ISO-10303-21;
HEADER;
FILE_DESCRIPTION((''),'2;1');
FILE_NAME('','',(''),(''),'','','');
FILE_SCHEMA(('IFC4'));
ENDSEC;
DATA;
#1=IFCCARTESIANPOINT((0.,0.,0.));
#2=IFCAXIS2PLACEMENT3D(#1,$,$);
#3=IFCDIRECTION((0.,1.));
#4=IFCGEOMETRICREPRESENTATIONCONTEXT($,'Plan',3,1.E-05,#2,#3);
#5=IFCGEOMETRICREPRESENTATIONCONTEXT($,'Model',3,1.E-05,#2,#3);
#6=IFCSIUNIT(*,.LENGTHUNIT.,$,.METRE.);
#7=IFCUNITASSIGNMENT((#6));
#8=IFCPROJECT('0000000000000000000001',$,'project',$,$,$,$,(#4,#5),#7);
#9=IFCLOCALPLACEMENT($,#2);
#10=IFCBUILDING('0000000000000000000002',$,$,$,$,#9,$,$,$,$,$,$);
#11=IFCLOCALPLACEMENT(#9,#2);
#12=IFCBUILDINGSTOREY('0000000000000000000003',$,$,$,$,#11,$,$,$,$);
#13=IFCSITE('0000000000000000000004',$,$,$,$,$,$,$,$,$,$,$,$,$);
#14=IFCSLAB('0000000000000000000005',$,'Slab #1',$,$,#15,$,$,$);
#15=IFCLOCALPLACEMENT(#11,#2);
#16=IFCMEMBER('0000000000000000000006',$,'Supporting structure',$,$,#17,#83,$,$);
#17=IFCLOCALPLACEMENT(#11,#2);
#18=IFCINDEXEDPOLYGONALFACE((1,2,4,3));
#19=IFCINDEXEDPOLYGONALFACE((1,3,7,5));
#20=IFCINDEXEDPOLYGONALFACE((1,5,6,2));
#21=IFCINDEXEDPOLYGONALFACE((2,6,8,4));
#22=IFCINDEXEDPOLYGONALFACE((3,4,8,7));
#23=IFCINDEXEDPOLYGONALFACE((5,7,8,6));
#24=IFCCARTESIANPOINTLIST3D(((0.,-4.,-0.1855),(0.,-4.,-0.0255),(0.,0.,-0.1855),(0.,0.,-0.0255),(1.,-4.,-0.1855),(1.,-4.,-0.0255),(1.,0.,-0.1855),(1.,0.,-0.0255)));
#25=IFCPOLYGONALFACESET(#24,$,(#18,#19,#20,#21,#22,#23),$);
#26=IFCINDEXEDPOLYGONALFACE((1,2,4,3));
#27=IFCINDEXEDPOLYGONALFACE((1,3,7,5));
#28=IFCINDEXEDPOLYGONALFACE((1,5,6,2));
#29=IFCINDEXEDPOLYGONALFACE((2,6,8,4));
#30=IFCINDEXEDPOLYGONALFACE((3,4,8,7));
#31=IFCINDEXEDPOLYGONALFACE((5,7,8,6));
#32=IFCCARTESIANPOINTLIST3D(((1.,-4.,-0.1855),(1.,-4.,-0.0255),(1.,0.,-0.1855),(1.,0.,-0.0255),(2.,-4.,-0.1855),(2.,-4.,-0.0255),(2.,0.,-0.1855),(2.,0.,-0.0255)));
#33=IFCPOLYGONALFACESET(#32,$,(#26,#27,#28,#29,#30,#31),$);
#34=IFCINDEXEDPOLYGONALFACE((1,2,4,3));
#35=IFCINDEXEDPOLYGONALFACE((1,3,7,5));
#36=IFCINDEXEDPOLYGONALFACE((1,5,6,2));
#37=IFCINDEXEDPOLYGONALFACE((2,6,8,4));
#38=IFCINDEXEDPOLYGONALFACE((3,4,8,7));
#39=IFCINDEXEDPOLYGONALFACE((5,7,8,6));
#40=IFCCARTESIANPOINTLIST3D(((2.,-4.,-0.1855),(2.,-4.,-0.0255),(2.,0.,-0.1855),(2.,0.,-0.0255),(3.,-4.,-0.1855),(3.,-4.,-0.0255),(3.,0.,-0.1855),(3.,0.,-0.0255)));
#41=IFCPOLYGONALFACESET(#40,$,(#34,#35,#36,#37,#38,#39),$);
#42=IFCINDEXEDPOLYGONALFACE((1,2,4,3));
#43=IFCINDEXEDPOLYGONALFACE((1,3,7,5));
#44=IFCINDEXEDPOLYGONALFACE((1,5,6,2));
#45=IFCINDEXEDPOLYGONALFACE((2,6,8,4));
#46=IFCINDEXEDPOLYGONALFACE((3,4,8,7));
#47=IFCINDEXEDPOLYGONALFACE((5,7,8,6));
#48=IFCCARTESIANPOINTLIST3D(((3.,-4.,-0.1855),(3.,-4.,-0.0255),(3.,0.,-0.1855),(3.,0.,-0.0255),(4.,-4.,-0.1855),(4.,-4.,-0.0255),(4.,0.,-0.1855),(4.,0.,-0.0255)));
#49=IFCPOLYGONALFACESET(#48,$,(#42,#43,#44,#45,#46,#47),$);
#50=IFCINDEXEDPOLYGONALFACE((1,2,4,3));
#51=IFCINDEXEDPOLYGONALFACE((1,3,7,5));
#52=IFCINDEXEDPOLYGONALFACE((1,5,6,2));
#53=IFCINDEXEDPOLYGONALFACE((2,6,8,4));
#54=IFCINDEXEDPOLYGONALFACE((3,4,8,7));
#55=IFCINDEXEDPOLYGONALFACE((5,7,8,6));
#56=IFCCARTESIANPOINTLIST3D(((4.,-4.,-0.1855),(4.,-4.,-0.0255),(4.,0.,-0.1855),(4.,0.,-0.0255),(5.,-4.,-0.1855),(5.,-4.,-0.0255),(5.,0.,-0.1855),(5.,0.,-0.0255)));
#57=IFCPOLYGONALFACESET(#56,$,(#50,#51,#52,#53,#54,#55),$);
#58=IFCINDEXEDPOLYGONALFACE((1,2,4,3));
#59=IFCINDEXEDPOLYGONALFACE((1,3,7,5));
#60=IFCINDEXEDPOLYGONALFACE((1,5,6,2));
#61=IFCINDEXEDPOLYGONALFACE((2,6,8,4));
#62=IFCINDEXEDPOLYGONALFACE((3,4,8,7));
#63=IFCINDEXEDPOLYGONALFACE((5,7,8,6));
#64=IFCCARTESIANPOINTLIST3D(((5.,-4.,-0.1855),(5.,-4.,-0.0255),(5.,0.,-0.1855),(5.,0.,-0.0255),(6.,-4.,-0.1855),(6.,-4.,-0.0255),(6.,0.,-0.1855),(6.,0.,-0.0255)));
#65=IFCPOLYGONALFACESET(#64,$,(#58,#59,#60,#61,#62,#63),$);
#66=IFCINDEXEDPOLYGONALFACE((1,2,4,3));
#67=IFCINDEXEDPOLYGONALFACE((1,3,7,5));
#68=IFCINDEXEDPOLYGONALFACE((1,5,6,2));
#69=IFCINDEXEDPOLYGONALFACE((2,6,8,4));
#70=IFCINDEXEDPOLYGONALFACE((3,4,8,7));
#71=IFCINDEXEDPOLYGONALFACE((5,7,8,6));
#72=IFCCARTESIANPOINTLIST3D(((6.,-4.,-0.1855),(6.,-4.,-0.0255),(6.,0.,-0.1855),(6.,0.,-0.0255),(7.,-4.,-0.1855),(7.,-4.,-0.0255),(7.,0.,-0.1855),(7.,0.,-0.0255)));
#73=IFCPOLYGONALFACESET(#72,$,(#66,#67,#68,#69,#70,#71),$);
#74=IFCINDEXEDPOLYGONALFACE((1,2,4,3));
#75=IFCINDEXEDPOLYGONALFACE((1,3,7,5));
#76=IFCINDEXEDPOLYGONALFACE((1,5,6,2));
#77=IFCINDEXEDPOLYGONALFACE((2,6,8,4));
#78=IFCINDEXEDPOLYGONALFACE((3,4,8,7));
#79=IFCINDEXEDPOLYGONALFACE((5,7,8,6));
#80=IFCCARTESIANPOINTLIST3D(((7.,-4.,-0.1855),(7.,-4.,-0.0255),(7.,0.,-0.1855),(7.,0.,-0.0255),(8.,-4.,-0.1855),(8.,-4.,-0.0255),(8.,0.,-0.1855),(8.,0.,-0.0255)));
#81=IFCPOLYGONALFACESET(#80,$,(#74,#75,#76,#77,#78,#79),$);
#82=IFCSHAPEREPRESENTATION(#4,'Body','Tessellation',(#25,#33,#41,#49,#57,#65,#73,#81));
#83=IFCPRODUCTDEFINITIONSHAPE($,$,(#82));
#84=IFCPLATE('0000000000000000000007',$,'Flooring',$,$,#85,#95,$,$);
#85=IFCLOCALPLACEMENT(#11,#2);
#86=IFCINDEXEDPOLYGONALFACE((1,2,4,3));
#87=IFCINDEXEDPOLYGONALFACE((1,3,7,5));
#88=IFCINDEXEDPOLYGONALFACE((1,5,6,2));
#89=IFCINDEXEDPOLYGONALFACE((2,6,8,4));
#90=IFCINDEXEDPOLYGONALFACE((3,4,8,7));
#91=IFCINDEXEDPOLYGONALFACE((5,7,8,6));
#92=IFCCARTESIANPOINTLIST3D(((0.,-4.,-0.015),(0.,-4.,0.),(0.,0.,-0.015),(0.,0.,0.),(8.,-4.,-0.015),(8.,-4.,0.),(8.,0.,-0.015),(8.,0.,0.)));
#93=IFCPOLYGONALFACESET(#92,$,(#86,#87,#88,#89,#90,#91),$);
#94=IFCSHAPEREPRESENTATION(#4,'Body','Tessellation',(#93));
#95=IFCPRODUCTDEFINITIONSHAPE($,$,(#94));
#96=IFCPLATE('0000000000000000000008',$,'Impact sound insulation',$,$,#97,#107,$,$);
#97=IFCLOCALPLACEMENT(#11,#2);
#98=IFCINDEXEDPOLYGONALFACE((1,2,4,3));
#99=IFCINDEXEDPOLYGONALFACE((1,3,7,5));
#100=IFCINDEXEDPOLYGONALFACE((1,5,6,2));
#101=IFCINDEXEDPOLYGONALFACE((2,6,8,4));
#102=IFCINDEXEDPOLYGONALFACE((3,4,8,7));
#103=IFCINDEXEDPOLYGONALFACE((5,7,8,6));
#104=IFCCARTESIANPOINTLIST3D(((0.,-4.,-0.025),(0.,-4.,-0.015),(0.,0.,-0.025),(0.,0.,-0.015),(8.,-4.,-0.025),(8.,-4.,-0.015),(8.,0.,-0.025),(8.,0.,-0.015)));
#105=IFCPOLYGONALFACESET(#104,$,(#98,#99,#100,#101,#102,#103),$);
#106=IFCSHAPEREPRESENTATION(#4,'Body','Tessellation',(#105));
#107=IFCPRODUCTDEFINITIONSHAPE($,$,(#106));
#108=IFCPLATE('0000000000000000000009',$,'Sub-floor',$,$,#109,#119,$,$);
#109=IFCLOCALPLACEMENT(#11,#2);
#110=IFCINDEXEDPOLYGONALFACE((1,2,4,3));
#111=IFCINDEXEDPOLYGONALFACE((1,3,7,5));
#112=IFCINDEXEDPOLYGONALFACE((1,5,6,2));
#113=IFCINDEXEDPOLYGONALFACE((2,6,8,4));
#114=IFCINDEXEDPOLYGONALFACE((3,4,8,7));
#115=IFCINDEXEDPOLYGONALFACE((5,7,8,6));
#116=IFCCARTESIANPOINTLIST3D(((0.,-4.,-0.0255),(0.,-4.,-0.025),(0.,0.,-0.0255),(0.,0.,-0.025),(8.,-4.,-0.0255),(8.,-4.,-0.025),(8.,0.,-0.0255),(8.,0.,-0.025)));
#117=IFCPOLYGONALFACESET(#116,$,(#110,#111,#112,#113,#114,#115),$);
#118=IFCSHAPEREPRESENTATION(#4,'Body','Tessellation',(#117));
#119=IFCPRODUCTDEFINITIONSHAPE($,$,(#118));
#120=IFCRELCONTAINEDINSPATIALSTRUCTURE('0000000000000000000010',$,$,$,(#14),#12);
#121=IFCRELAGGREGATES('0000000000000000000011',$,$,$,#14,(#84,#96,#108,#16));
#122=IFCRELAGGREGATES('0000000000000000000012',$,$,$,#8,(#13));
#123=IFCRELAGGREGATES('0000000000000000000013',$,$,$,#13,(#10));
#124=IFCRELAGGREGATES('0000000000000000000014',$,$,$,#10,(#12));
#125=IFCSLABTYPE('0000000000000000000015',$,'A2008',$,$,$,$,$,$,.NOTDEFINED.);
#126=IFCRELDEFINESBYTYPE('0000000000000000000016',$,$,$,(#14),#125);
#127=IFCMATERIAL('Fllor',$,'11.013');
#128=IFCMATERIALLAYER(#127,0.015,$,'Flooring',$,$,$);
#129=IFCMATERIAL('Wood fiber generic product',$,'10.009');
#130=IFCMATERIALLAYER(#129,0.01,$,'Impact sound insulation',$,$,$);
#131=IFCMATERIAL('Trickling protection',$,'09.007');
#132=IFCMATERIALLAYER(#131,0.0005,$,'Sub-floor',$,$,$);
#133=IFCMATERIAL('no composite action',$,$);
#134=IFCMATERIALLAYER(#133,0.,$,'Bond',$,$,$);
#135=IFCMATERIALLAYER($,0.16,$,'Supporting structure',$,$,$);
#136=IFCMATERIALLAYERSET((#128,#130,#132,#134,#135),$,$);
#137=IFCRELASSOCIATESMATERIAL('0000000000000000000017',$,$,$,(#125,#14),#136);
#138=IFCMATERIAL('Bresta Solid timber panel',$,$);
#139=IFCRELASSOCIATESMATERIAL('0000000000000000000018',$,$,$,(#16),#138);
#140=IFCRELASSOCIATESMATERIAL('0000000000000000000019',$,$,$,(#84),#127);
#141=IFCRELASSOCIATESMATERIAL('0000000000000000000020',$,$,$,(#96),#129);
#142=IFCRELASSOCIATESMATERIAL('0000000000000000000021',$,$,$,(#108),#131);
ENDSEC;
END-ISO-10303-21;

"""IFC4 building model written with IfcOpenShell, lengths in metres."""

from ifc_helpers import new_model, si_unit, direction, frame, frame_2d, origin, origin_with_axes, place, context, project, spatial, rectangle, extrude, material, layer, layer_set, type_object, element, aggregate, save


model = new_model("IFC4")

# Units and contexts
plan_context = context("Plan", 3, precision=1e-05, world=origin(), true_north=direction((0.0, 1.0)))
model_context = context("Model", 3, precision=1e-05, world=origin(), true_north=direction((0.0, 1.0)))
ifc_project = project(units=[si_unit("LENGTHUNIT", "METRE")], contexts=[plan_context, model_context])

# Site, building, storey
site = spatial("IfcSite", under=ifc_project)
building_placement = place(None, origin())
building = spatial("IfcBuilding", under=site, at=building_placement)
storey_placement = place(building_placement, origin())
storey = spatial("IfcBuildingStorey", under=building, at=storey_placement)

# Slab, member, plates
ifc_material_1 = material(Name="Fllor", Category="11.013")
ifc_layer_1 = layer(ifc_material_1, 0.015, Name="Flooring")
ifc_material_2 = material(Name="Wood fiber generic product", Category="10.009")
ifc_layer_2 = layer(ifc_material_2, 0.01, Name="Impact sound insulation")
ifc_material_3 = material(Name="Trickling protection", Category="09.007")
ifc_layer_3 = layer(ifc_material_3, 0.0005, Name="Sub-floor")
ifc_material_4 = material(Name="no composite action")
ifc_layer_4 = layer(ifc_material_4, 0.0, Name="Bond")
ifc_layer_5 = layer(None, 0.16, Name="Supporting structure")
ifc_layer_set = layer_set([ifc_layer_1, ifc_layer_2, ifc_layer_3, ifc_layer_4, ifc_layer_5])
slab_type = type_object("IfcSlabType", Name="A2008", PredefinedType="NOTDEFINED", material=ifc_layer_set)
slab_placement = place(None, frame((0.0, 0.0, 0.0), z_axis=(0.0, 0.0, -1.0), x_axis=(1.0, 0.0, 0.0)))
slab = element("IfcSlab", 1, at=slab_placement, inside=storey, type_object=slab_type, material=ifc_layer_set, Name="Slab #1")
ifc_material_5 = material(Name="Bresta Solid timber panel")
member_placement = place(slab_placement, origin())
member = element("IfcMember", 2, at=member_placement, material=ifc_material_5, Name="Supporting structure", context=plan_context, shape_type="SweptSolid", body=[
    extrude(rectangle(XDim=1.0, YDim=0.16, at=frame_2d((0.5, 0.08), x_axis=(1.0, 0.0))), frame((0.0, 4.0, 0.0255), z_axis=(0.0, -1.0, 0.0), x_axis=(1.0, 0.0, 0.0)), (0.0, 0.0, 1.0), 4.0),
    extrude(rectangle(XDim=1.0, YDim=0.16, at=frame_2d((0.5, 0.08), x_axis=(1.0, 0.0))), frame((1.0, 4.0, 0.0255), z_axis=(0.0, -1.0, 0.0), x_axis=(1.0, 0.0, 0.0)), (0.0, 0.0, 1.0), 4.0),
    extrude(rectangle(XDim=1.0, YDim=0.16, at=frame_2d((0.5, 0.08), x_axis=(1.0, 0.0))), frame((2.0, 4.0, 0.0255), z_axis=(0.0, -1.0, 0.0), x_axis=(1.0, 0.0, 0.0)), (0.0, 0.0, 1.0), 4.0),
    extrude(rectangle(XDim=1.0, YDim=0.16, at=frame_2d((0.5, 0.08), x_axis=(1.0, 0.0))), frame((3.0, 4.0, 0.0255), z_axis=(0.0, -1.0, 0.0), x_axis=(1.0, 0.0, 0.0)), (0.0, 0.0, 1.0), 4.0),
    extrude(rectangle(XDim=1.0, YDim=0.16, at=frame_2d((0.5, 0.08), x_axis=(1.0, 0.0))), frame((4.0, 4.0, 0.0255), z_axis=(0.0, -1.0, 0.0), x_axis=(1.0, 0.0, 0.0)), (0.0, 0.0, 1.0), 4.0),
    extrude(rectangle(XDim=1.0, YDim=0.16, at=frame_2d((0.5, 0.08), x_axis=(1.0, 0.0))), frame((5.0, 4.0, 0.0255), z_axis=(0.0, -1.0, 0.0), x_axis=(1.0, 0.0, 0.0)), (0.0, 0.0, 1.0), 4.0),
    extrude(rectangle(XDim=1.0, YDim=0.16, at=frame_2d((0.5, 0.08), x_axis=(1.0, 0.0))), frame((6.0, 4.0, 0.0255), z_axis=(0.0, -1.0, 0.0), x_axis=(1.0, 0.0, 0.0)), (0.0, 0.0, 1.0), 4.0),
    extrude(rectangle(XDim=1.0, YDim=0.16, at=frame_2d((0.5, 0.08), x_axis=(1.0, 0.0))), frame((7.0, 4.0, 0.0255), z_axis=(0.0, -1.0, 0.0), x_axis=(1.0, 0.0, 0.0)), (0.0, 0.0, 1.0), 4.0),
])
plate_1_placement = place(slab_placement, origin())
plate_1 = element("IfcPlate", 3, at=plate_1_placement, material=ifc_material_1, Name="Flooring", context=plan_context, shape_type="SweptSolid", body=[
    extrude(rectangle(XDim=8.0, YDim=4.0, at=frame_2d((4.0, 2.0), x_axis=(1.0, 0.0))), origin_with_axes(), (0.0, 0.0, 1.0), 0.015),
])
plate_2_placement = place(slab_placement, origin())
plate_2 = element("IfcPlate", 4, at=plate_2_placement, material=ifc_material_2, Name="Impact sound insulation", context=plan_context, shape_type="SweptSolid", body=[
    extrude(rectangle(XDim=8.0, YDim=4.0, at=frame_2d((4.0, 2.0), x_axis=(1.0, 0.0))), frame((0.0, 0.0, 0.015), z_axis=(0.0, 0.0, 1.0), x_axis=(1.0, 0.0, 0.0)), (0.0, 0.0, 1.0), 0.01),
])
plate_3_placement = place(slab_placement, origin())
plate_3 = element("IfcPlate", 5, at=plate_3_placement, material=ifc_material_3, Name="Sub-floor", context=plan_context, shape_type="SweptSolid", body=[
    extrude(rectangle(XDim=8.0, YDim=4.0, at=frame_2d((4.0, 2.0), x_axis=(1.0, 0.0))), frame((0.0, 0.0, 0.025), z_axis=(0.0, 0.0, 1.0), x_axis=(1.0, 0.0, 0.0)), (0.0, 0.0, 1.0), 0.0005),
])
aggregate(slab, [plate_1, plate_2, plate_3, member])

save(model, "model.ifc")
